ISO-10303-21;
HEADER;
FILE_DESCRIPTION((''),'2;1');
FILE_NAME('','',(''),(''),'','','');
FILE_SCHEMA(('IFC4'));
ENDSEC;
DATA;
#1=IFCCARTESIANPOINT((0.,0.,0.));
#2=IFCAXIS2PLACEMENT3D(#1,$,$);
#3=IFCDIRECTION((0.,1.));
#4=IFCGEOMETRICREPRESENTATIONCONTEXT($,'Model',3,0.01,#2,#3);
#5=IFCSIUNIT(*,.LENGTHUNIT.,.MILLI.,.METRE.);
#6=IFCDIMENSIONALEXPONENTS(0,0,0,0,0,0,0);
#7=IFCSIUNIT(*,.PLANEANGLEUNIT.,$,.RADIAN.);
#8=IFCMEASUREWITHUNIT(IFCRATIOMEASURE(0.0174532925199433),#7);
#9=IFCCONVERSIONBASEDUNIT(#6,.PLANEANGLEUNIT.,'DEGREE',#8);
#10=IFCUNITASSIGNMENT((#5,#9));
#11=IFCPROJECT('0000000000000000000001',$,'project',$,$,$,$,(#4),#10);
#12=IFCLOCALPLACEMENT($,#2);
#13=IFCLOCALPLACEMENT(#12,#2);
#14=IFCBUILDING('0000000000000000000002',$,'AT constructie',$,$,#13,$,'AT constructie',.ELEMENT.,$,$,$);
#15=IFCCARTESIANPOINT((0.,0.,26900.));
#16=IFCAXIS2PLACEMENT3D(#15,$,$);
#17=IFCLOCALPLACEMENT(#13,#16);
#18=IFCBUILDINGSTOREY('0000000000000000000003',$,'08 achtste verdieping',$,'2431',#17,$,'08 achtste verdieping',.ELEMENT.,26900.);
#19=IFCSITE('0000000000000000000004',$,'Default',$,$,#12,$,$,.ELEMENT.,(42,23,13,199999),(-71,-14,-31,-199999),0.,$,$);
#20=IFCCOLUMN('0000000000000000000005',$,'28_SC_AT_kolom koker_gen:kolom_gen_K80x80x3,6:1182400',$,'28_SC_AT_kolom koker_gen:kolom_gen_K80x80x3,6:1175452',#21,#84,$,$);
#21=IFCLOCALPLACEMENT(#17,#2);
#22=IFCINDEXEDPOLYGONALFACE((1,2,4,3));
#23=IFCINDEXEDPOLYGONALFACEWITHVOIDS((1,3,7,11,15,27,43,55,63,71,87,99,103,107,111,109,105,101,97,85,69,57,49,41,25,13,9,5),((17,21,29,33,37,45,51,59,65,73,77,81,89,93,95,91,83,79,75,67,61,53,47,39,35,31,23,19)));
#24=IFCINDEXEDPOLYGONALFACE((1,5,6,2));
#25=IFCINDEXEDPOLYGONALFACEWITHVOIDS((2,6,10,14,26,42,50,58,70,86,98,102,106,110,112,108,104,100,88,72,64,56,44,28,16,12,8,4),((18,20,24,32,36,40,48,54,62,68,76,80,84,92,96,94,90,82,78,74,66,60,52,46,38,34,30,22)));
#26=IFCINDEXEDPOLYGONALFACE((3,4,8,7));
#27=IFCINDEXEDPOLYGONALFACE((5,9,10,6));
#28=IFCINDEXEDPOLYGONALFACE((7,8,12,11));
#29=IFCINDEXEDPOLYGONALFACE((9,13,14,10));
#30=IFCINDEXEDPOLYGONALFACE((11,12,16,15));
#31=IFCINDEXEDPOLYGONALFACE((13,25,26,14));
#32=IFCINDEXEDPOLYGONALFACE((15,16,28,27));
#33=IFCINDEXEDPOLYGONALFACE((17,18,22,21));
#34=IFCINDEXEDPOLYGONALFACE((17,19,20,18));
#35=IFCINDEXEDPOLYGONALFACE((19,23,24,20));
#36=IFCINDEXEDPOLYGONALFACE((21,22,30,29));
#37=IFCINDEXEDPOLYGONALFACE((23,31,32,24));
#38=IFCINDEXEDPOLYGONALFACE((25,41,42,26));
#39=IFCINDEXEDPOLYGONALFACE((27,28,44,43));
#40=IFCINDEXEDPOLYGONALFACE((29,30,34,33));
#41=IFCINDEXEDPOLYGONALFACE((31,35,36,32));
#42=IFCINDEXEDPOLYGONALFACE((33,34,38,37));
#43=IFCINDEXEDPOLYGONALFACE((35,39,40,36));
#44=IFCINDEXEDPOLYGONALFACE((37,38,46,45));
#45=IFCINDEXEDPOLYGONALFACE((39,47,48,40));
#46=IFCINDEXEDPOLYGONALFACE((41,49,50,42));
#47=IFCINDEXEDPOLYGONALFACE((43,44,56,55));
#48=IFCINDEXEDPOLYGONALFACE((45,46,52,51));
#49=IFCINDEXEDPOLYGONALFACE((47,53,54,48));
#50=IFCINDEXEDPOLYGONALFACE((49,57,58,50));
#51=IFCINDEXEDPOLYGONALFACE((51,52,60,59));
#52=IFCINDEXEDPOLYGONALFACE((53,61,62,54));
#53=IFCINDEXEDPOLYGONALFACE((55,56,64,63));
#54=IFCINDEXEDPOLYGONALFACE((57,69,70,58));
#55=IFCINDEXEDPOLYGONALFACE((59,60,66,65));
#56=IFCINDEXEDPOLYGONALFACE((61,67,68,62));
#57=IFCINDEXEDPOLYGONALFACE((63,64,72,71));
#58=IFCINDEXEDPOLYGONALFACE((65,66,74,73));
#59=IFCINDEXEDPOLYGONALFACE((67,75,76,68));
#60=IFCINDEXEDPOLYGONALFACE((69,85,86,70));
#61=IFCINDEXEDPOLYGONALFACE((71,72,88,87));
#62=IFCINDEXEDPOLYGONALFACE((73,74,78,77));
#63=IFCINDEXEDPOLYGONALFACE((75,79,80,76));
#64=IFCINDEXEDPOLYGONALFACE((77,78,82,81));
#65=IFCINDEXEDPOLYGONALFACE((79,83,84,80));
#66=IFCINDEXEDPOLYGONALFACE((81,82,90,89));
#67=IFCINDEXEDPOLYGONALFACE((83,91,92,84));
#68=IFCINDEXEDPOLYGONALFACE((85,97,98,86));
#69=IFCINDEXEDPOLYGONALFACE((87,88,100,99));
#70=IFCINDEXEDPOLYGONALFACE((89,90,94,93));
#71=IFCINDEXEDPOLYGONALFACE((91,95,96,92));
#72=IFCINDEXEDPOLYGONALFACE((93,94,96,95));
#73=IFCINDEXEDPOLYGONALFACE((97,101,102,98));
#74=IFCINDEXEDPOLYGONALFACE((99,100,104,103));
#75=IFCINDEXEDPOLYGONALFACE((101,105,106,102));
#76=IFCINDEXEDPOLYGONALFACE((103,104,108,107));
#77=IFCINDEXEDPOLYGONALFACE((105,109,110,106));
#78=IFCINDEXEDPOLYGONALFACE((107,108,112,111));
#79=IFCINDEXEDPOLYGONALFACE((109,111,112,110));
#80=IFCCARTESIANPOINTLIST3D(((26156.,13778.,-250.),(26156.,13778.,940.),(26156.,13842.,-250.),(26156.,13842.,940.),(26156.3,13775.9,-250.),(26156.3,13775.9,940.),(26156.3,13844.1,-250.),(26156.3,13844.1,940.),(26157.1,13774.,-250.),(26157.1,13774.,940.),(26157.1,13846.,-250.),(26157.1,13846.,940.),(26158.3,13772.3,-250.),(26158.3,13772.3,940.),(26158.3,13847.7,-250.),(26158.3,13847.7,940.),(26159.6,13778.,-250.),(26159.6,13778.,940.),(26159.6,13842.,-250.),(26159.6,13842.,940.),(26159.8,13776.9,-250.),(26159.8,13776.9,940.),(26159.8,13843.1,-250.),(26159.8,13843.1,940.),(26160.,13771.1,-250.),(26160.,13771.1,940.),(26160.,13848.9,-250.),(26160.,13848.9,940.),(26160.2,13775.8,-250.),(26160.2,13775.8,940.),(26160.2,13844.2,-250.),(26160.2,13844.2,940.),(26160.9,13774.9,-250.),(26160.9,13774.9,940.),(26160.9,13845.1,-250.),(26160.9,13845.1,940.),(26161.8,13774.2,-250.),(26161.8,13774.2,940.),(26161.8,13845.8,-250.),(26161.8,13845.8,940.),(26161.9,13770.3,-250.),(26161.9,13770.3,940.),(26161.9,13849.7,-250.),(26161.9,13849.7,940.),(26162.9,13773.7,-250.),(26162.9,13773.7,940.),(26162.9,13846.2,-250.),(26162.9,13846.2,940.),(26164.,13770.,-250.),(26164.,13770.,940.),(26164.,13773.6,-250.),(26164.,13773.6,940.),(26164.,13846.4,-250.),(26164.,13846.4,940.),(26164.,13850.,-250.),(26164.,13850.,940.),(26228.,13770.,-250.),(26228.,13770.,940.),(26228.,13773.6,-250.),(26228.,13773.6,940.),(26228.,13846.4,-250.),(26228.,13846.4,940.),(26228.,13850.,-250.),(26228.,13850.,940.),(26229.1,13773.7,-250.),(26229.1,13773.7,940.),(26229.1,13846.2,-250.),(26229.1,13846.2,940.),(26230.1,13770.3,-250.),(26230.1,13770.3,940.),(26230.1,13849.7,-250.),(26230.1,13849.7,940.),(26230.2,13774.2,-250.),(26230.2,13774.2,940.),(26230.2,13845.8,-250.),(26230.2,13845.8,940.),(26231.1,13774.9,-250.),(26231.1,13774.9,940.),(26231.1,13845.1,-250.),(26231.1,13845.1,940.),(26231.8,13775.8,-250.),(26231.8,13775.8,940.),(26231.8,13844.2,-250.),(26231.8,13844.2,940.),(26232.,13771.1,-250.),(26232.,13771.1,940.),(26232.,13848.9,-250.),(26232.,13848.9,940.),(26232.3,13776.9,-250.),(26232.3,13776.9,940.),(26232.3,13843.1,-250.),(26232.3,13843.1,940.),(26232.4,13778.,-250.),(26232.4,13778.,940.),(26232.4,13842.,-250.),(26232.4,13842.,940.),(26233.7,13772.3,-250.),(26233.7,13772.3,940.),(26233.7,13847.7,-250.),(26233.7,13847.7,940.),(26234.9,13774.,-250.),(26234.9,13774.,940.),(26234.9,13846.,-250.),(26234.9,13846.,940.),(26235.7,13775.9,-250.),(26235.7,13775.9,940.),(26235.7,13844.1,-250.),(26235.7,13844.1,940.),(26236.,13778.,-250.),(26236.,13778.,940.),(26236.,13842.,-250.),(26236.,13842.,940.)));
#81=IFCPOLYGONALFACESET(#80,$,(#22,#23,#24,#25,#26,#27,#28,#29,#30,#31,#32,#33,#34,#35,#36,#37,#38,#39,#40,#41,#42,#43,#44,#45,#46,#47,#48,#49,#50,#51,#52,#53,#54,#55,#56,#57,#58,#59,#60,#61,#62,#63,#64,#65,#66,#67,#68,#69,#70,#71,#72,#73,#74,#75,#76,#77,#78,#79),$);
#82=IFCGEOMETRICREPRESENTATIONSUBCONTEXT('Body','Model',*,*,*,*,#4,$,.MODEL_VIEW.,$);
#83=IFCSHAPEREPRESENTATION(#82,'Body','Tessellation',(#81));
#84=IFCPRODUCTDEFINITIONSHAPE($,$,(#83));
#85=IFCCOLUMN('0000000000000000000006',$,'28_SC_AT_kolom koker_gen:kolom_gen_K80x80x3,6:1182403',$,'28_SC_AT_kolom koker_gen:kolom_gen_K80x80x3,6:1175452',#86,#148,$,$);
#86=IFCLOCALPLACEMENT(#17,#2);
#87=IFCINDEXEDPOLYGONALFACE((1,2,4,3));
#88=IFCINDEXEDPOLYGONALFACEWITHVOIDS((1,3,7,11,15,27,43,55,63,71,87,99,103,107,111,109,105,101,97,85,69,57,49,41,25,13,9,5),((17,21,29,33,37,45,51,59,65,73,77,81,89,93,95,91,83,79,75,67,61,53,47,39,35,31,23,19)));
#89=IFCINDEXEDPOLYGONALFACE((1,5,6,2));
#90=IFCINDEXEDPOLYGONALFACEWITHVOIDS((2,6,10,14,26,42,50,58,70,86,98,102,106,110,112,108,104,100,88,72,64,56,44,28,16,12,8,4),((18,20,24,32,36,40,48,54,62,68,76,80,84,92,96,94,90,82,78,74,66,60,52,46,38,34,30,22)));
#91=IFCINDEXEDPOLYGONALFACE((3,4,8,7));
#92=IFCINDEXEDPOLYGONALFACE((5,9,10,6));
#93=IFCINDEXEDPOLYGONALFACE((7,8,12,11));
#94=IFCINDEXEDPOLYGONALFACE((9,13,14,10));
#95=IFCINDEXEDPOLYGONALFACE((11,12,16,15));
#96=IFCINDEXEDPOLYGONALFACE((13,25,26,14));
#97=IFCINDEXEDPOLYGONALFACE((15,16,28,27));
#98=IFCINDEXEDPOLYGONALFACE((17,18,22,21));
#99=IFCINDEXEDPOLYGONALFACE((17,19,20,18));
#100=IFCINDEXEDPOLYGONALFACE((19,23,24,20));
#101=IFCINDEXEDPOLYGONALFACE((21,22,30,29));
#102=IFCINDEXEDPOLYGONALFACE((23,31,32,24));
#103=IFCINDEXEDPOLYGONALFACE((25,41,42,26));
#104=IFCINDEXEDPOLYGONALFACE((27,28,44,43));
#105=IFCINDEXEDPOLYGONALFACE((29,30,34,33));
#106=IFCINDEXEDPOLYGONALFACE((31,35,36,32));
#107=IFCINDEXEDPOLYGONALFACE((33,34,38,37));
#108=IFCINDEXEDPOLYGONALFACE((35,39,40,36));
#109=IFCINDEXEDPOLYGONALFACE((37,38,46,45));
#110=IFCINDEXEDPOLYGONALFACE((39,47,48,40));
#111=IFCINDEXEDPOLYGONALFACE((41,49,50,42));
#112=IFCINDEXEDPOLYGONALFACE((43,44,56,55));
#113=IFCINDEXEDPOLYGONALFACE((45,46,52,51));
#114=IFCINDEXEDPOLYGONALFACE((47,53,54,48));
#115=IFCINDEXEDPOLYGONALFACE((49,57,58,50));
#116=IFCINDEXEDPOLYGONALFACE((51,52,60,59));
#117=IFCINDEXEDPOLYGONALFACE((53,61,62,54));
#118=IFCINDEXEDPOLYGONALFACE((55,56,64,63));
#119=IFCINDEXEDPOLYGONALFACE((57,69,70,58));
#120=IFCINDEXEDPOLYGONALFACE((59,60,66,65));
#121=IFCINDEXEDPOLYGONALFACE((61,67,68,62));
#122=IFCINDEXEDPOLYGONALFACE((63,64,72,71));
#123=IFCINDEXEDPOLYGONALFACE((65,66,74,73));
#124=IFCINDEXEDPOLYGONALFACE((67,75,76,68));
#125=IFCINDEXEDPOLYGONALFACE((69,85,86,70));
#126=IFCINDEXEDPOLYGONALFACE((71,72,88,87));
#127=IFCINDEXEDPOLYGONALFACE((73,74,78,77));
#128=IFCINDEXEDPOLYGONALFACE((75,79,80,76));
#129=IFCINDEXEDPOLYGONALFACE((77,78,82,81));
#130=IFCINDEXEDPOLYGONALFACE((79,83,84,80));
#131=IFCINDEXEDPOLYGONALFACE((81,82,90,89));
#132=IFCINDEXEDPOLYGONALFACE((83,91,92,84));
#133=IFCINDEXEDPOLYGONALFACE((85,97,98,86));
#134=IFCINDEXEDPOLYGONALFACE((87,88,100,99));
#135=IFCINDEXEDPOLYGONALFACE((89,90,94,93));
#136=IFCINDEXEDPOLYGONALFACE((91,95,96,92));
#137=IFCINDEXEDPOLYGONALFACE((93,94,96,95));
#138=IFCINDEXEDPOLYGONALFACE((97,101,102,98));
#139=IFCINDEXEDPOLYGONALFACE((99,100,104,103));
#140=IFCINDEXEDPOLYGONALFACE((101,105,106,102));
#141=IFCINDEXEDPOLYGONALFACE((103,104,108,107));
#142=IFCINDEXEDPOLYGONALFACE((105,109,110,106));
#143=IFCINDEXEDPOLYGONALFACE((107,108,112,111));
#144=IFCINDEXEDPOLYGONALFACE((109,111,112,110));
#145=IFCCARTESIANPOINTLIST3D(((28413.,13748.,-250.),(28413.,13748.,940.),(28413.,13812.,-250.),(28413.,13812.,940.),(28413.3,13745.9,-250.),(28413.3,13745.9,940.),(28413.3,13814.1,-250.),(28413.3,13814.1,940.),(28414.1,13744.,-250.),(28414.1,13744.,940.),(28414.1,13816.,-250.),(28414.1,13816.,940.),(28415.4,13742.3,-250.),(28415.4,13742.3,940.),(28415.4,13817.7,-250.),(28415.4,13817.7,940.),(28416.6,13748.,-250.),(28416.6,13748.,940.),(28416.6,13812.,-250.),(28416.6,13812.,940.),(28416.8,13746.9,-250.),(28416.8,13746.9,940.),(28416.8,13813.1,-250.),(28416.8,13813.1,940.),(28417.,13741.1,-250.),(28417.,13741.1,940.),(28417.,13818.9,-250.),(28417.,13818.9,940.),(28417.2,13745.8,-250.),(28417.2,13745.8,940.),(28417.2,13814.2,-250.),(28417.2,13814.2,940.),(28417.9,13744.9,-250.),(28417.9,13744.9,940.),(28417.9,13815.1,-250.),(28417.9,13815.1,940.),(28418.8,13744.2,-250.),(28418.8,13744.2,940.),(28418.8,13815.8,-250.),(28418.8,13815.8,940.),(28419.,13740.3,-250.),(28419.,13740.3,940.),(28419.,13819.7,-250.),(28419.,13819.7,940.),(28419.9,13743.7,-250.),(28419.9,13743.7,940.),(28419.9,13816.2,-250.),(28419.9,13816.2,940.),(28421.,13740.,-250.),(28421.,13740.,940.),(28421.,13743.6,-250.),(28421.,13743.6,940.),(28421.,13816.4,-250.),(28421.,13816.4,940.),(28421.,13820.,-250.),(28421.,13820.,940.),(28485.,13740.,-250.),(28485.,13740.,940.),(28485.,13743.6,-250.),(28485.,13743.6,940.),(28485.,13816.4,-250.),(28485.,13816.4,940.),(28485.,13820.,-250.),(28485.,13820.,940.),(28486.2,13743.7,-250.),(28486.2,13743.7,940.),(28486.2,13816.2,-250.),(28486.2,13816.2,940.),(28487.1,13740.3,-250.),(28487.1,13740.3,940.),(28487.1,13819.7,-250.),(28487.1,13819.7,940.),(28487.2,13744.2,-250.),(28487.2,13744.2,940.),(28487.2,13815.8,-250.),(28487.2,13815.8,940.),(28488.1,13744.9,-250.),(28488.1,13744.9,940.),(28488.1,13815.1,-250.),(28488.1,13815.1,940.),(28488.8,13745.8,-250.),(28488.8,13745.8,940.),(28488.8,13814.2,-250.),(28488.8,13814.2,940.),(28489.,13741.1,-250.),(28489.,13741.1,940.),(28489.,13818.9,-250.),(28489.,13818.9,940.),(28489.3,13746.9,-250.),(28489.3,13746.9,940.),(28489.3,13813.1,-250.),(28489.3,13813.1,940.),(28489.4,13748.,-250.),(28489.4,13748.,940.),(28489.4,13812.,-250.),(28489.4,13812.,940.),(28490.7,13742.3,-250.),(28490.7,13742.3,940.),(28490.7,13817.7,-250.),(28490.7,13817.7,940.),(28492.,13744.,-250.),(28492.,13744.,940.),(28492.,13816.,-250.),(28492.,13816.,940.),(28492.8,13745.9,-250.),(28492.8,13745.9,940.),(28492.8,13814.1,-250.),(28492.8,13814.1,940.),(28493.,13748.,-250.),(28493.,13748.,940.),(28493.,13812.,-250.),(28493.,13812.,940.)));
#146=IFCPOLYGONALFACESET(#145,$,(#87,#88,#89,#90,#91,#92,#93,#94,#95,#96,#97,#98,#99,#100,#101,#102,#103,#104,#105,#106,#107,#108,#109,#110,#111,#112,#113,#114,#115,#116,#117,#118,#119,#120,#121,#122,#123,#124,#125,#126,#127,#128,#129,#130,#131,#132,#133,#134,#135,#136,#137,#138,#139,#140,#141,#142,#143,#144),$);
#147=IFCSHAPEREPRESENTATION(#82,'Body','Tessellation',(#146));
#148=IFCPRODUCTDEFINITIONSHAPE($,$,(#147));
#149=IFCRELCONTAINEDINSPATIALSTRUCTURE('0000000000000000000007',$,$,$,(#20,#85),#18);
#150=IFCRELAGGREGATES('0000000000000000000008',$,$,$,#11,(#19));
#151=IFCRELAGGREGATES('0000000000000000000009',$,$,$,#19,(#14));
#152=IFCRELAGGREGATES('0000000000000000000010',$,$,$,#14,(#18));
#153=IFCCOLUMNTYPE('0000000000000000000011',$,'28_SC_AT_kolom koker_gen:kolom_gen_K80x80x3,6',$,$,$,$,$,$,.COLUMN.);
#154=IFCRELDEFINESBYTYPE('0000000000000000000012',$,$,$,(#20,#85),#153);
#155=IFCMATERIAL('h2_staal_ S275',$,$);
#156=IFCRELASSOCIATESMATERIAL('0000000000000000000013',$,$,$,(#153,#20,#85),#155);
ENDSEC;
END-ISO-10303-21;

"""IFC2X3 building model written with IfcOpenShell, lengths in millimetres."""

from ifc_helpers import new_model, entity, si_unit, converted_unit, direction, frame, frame_2d, origin, place, context, subcontext, project, spatial, polyline, circle_curve, parameter, trimmed, segment, composite_curve, outline, extrude, source, transform, mapped, material, type_object, type_shapes, element, save


model = new_model("IFC2X3")

# Units and contexts
model_context = context("Model", 3, precision=0.01, world=origin(), true_north=direction((0.0, 1.0)))
body_context = subcontext(model_context, "Body", "Model", "MODEL_VIEW")
ifc_project = project(units=[si_unit("LENGTHUNIT", "METRE", prefix="MILLI"), converted_unit("PLANEANGLEUNIT", "DEGREE", entity("IfcRatioMeasure", 0.0174532925199433), si_unit("PLANEANGLEUNIT", "RADIAN"), dimensions=[0, 0, 0, 0, 0, 0, 0])], contexts=[model_context])

# Site, building, storey
site_placement = place(None, origin())
site = spatial("IfcSite", under=ifc_project, at=site_placement, Name="Default", CompositionType="ELEMENT", RefLatitude=(42, 23, 13, 199999), RefLongitude=(-71, -14, -31, -199999), RefElevation=0.0)
building_placement = place(site_placement, origin())
building = spatial("IfcBuilding", under=site, at=building_placement, Name="AT constructie", LongName="AT constructie", CompositionType="ELEMENT")
storey_placement = place(building_placement, frame((0.0, 0.0, 26900.0)))
storey = spatial("IfcBuildingStorey", under=building, at=storey_placement, Name="08 achtste verdieping", ObjectType="2431", LongName="08 achtste verdieping", CompositionType="ELEMENT", Elevation=26900.0)

# Columns
ifc_material_1 = material(Name="h2_staal_ S275")
column_type_1 = type_object("IfcColumnType", Name="28_SC_AT_kolom koker_gen:kolom_gen_K80x80x3,6", PredefinedType="COLUMN", material=ifc_material_1)
shared_shape_1 = source(origin(), body_context, "Body", "SweptSolid", [
    extrude(outline(composite_curve([segment(trimmed(circle_curve(frame_2d((32.0, 32.0), x_axis=(1.0, 0.0)), 8.0), [parameter(360.0)], [parameter(90.0)], True, "PARAMETER"), True, "CONTINUOUS"), segment(polyline([(32.0, 40.0), (-32.0, 40.0)]), True, "CONTINUOUS"), segment(trimmed(circle_curve(frame_2d((-32.0, 32.0), x_axis=(1.0, 0.0)), 8.0), [parameter(90.0)], [parameter(180.0)], True, "PARAMETER"), True, "CONTINUOUS"), segment(polyline([(-40.0, 32.0), (-40.0, -32.0)]), True, "CONTINUOUS"), segment(trimmed(circle_curve(frame_2d((-32.0, -32.0), x_axis=(1.0, 0.0)), 8.0), [parameter(180.0)], [parameter(270.0)], True, "PARAMETER"), True, "CONTINUOUS"), segment(polyline([(-32.0, -40.0), (32.0, -40.0)]), True, "CONTINUOUS"), segment(trimmed(circle_curve(frame_2d((32.0, -32.0), x_axis=(1.0, 0.0)), 8.0), [parameter(270.0)], [parameter(0.0)], True, "PARAMETER"), True, "CONTINUOUS"), segment(polyline([(40.0, -32.0), (40.0, 32.0)]), True, "CONTINUOUS")], self_intersect=False), holes=[composite_curve([segment(polyline([(-32.0, 36.4), (32.0, 36.4)]), True, "CONTINUOUS"), segment(trimmed(circle_curve(frame_2d((32.0, 32.0), x_axis=(1.0, 0.0)), 4.4), [parameter(360.0)], [parameter(90.0)], True, "PARAMETER"), False, "CONTINUOUS"), segment(polyline([(36.4, 32.0), (36.4, -32.0)]), True, "CONTINUOUS"), segment(trimmed(circle_curve(frame_2d((32.0, -32.0), x_axis=(1.0, 0.0)), 4.4), [parameter(270.0)], [parameter(360.0)], True, "PARAMETER"), False, "CONTINUOUS"), segment(polyline([(32.0, -36.4), (-32.0, -36.4)]), True, "CONTINUOUS"), segment(trimmed(circle_curve(frame_2d((-32.0, -32.0), x_axis=(1.0, 0.0)), 4.4), [parameter(180.0)], [parameter(270.0)], True, "PARAMETER"), False, "CONTINUOUS"), segment(polyline([(-36.4, -32.0), (-36.4, 32.0)]), True, "CONTINUOUS"), segment(trimmed(circle_curve(frame_2d((-32.0, 32.0), x_axis=(1.0, 0.0)), 4.4), [parameter(90.0)], [parameter(180.0)], True, "PARAMETER"), False, "CONTINUOUS")], self_intersect=False)]), frame((0.0, 0.0, 26650.0), z_axis=(0.0, 0.0, 1.0), x_axis=(-1.0, 0.0, 0.0)), (0.0, 0.0, 1.0), 1190.0),
])
type_shapes(column_type_1, [shared_shape_1])
for number, where, name in (
    (1, (26196.0, 13810.0, -26900.0), "28_SC_AT_kolom koker_gen:kolom_gen_K80x80x3,6:1182400"),
    (2, (28453.0, 13780.0, -26900.0), "28_SC_AT_kolom koker_gen:kolom_gen_K80x80x3,6:1182403"),
):
    element("IfcColumn", number, at=place(storey_placement, frame(where)), inside=storey, type_object=column_type_1, material=ifc_material_1, Name=name, ObjectType="28_SC_AT_kolom koker_gen:kolom_gen_K80x80x3,6:1175452", context=body_context, shape_type="MappedRepresentation", body=[
        mapped(shared_shape_1, transform((0.0, 0.0, 0.0), scale=1.0)),
    ])

save(model, "model.ifc")
